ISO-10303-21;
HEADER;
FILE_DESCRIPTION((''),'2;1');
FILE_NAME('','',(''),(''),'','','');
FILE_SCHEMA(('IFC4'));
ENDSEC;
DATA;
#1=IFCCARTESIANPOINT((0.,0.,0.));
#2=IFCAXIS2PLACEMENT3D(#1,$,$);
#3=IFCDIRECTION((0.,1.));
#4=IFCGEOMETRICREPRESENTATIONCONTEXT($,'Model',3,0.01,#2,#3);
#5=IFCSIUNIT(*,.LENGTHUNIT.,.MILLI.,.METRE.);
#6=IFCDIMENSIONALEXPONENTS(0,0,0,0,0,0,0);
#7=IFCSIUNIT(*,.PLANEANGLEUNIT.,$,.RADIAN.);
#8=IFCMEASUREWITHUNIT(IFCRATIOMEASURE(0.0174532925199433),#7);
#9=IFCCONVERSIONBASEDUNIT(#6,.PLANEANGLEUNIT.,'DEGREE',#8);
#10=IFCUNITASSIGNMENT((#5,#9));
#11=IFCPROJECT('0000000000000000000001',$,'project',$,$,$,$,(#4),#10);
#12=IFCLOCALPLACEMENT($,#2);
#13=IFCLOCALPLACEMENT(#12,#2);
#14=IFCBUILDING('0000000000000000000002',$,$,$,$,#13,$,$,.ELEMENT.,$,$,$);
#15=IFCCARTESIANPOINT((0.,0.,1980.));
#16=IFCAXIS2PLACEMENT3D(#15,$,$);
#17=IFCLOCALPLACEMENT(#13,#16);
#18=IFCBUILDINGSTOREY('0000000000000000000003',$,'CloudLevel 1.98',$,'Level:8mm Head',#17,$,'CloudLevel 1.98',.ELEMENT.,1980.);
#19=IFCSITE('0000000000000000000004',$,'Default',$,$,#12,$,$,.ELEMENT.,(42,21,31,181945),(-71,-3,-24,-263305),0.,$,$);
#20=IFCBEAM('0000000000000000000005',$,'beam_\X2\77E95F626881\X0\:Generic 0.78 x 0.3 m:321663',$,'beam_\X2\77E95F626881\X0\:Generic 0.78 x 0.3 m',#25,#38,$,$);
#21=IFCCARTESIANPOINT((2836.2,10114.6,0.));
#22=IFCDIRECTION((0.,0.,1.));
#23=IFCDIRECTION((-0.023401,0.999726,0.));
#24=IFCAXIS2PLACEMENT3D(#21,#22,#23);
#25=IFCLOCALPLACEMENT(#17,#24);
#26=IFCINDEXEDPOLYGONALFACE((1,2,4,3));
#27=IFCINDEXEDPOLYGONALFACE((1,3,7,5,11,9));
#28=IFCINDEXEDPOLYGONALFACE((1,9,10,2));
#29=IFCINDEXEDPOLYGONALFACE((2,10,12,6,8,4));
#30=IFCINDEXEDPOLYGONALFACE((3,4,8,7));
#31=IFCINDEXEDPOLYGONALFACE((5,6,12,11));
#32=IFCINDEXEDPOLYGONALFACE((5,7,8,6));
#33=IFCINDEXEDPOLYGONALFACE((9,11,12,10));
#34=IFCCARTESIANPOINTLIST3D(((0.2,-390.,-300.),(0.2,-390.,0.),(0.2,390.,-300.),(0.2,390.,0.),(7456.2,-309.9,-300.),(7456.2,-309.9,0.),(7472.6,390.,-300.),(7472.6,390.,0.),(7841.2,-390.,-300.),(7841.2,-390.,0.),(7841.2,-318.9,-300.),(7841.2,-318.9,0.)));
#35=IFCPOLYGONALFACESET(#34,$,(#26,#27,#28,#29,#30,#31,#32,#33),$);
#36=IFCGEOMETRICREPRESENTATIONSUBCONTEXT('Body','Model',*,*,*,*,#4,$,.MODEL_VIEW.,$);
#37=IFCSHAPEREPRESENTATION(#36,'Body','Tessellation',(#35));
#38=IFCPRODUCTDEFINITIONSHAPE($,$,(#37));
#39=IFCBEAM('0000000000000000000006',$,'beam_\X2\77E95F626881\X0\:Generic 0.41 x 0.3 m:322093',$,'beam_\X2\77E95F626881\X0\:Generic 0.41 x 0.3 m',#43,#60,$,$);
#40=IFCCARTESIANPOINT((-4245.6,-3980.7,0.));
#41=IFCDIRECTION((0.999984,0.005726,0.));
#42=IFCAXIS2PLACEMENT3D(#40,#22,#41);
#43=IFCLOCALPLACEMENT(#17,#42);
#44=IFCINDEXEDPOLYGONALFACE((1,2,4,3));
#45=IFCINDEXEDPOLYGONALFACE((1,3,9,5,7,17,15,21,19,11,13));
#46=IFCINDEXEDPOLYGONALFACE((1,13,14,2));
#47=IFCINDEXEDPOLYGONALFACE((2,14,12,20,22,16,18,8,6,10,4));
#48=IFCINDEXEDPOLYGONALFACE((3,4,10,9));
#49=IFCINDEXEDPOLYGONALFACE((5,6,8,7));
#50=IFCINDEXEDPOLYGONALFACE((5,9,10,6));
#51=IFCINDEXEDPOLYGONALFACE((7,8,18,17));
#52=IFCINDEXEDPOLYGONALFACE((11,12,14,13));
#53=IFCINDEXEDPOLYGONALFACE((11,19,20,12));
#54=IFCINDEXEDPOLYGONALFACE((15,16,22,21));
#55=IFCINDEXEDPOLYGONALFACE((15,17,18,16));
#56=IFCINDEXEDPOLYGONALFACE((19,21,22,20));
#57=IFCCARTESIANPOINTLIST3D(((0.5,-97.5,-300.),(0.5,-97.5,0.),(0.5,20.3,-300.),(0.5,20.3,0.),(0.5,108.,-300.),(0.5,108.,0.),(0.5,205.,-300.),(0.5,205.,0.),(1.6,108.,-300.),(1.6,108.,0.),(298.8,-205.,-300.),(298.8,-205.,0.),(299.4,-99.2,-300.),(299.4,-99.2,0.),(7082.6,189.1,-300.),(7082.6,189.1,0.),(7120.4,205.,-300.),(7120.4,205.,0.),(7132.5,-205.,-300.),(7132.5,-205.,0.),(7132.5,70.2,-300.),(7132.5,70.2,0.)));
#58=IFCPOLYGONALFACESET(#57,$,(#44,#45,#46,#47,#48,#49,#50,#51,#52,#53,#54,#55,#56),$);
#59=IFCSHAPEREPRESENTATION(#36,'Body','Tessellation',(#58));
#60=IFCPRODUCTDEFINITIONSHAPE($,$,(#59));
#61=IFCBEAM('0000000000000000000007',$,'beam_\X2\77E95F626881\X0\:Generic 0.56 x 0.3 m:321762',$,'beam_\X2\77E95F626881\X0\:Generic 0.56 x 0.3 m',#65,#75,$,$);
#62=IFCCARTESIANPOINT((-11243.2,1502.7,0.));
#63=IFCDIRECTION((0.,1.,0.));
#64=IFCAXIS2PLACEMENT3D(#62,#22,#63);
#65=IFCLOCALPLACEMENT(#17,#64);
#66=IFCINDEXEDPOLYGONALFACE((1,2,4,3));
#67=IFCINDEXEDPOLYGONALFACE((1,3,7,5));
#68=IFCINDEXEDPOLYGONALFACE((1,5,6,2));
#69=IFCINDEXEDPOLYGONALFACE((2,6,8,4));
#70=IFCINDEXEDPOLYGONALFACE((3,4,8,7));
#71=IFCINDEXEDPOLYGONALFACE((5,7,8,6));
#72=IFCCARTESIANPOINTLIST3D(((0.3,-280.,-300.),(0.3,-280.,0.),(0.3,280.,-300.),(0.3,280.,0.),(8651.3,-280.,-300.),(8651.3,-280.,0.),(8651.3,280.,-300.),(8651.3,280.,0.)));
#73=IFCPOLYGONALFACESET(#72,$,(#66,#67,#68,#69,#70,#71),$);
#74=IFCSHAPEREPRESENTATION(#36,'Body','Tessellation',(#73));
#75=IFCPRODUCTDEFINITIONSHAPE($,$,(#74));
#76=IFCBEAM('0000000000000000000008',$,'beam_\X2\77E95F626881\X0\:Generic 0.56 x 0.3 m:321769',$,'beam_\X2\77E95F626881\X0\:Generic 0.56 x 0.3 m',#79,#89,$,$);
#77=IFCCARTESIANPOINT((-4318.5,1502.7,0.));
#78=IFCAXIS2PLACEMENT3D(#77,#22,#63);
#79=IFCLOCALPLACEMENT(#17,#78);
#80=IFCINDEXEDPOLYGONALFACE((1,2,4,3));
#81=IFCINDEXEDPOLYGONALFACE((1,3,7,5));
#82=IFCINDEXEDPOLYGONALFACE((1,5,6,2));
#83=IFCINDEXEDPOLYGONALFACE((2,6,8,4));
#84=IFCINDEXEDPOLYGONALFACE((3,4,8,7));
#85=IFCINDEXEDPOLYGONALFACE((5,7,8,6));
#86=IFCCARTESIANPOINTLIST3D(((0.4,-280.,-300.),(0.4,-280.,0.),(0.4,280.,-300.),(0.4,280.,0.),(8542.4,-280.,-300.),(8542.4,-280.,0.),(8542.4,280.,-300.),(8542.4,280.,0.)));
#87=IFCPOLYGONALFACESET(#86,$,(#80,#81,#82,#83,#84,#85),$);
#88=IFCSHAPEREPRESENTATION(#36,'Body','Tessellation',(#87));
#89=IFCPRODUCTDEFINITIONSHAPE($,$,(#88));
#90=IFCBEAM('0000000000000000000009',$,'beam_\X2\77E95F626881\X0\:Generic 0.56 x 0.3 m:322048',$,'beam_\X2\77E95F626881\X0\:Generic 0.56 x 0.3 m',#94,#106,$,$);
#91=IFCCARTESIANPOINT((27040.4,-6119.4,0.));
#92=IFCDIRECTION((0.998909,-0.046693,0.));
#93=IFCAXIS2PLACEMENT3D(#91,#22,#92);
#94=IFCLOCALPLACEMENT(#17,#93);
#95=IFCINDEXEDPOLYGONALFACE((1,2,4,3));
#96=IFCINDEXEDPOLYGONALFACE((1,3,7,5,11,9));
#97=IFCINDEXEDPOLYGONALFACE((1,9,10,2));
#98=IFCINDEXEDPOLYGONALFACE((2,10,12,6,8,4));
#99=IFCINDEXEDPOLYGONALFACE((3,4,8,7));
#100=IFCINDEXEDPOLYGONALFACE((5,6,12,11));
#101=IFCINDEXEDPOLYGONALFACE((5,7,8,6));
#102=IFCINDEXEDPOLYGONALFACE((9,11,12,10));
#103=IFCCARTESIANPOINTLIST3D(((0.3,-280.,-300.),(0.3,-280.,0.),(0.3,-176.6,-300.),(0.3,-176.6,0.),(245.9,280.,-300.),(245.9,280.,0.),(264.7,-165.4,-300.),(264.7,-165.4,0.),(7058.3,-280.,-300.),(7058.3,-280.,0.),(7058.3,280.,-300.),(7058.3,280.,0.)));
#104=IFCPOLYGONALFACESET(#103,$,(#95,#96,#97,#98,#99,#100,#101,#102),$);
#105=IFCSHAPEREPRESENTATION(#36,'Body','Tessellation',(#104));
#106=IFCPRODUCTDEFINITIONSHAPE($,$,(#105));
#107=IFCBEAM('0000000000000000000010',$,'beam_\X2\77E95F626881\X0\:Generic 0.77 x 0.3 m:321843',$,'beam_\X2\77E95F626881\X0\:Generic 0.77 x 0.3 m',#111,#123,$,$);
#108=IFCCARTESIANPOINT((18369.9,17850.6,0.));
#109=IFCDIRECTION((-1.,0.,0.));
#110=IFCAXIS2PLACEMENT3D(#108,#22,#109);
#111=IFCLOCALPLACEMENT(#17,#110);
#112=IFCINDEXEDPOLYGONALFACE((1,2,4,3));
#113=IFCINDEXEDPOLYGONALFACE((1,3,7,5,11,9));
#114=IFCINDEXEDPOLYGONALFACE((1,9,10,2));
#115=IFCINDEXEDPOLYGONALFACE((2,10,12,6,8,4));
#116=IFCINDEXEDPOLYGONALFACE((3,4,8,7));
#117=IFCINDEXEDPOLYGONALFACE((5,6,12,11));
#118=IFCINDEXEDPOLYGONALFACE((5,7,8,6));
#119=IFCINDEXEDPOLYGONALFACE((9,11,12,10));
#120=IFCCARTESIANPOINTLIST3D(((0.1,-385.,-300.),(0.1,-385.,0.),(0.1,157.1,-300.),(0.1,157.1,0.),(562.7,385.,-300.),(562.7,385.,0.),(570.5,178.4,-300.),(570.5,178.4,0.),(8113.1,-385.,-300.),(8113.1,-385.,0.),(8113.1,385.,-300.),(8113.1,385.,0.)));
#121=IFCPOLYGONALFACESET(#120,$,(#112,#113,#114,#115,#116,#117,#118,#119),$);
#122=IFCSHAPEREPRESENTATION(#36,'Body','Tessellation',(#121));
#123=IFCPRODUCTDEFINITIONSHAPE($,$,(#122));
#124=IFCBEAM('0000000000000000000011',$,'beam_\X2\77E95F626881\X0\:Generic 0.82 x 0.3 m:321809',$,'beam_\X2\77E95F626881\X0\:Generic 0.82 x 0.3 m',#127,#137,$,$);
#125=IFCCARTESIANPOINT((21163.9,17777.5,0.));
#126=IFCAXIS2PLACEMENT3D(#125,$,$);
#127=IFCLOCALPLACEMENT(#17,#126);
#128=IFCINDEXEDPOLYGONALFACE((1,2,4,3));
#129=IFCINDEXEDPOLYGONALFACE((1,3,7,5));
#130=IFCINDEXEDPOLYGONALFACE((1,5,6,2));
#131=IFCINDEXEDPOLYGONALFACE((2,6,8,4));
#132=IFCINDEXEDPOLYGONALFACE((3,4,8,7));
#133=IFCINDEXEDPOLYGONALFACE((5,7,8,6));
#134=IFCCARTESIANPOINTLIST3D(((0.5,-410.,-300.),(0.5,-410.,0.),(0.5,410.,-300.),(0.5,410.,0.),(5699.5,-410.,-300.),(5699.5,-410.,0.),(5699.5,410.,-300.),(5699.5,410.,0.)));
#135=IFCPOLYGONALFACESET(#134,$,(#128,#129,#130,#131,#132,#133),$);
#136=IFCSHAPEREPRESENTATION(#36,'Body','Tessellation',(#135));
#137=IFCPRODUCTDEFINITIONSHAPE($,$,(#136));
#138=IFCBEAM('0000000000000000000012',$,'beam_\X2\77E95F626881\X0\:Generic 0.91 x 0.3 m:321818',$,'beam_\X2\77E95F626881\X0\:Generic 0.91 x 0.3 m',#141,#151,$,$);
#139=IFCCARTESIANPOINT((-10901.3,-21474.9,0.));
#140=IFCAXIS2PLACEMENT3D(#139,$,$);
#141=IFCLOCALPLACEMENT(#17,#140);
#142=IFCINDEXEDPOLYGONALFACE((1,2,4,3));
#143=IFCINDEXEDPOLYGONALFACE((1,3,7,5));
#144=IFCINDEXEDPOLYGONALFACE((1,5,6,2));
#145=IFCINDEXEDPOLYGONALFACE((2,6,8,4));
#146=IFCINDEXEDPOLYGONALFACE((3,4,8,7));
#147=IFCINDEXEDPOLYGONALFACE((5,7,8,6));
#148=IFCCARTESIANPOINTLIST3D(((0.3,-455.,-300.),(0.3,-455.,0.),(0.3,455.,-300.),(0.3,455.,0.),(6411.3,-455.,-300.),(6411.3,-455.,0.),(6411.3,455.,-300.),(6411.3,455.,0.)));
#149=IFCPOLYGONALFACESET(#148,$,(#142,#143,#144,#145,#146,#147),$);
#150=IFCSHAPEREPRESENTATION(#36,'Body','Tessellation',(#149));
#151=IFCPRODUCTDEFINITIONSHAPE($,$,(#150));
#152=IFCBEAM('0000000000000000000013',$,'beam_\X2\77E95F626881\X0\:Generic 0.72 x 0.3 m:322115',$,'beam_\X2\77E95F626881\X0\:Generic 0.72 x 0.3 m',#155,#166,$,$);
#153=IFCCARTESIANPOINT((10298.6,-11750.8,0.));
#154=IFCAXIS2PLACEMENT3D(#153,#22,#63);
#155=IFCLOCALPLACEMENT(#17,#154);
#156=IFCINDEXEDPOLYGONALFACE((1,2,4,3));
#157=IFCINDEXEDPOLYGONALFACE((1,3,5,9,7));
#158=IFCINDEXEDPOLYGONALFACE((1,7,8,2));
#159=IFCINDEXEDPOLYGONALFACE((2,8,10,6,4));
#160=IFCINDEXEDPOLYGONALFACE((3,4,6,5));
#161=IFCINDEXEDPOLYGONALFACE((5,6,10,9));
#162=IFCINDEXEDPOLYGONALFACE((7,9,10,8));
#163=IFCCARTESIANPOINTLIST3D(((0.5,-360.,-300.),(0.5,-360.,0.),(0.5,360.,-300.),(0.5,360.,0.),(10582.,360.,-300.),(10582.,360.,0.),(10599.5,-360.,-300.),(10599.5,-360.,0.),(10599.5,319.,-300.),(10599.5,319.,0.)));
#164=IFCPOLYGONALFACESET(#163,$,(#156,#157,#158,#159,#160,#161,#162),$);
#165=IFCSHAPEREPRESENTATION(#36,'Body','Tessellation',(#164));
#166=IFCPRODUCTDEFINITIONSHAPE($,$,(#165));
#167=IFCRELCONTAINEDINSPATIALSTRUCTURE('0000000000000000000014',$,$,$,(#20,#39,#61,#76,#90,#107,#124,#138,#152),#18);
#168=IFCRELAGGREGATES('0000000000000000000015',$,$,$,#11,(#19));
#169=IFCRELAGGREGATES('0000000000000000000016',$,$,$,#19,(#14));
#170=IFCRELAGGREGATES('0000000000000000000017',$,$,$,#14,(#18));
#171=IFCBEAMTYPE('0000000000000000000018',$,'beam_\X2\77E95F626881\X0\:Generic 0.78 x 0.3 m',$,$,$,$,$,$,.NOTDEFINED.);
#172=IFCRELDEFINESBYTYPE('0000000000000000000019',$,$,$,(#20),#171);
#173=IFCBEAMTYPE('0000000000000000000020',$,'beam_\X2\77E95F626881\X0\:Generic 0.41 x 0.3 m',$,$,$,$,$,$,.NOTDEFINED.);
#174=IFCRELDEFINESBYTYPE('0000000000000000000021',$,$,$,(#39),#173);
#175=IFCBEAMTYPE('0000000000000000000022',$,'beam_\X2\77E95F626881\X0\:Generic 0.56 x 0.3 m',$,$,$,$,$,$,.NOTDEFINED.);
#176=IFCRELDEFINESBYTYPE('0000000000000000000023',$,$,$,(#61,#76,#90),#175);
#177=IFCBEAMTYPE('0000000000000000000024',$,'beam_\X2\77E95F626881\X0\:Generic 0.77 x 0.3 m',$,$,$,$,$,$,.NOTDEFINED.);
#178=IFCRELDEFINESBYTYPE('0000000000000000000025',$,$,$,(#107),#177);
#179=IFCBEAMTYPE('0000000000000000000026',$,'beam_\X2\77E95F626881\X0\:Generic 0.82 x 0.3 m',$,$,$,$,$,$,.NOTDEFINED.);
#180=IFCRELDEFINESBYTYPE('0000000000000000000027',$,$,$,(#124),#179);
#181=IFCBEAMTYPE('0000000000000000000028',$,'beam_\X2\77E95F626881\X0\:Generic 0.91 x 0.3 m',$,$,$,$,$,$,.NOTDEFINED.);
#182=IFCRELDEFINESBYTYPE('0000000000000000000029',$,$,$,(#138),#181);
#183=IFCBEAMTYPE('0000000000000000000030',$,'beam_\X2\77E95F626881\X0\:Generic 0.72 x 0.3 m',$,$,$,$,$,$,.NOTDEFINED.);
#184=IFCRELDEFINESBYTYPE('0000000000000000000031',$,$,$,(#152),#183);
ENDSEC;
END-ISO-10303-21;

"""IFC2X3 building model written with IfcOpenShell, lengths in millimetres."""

from ifc_helpers import new_model, entity, si_unit, converted_unit, direction, frame, frame_2d, origin, place, context, subcontext, project, spatial, polyline, rectangle, extrude, clip, halfspace, bounded_halfspace, type_object, element, save


model = new_model("IFC2X3")

# Units and contexts
model_context = context("Model", 3, precision=0.01, world=origin(), true_north=direction((0.0, 1.0)))
body_context = subcontext(model_context, "Body", "Model", "MODEL_VIEW")
ifc_project = project(units=[si_unit("LENGTHUNIT", "METRE", prefix="MILLI"), converted_unit("PLANEANGLEUNIT", "DEGREE", entity("IfcRatioMeasure", 0.0174532925199433), si_unit("PLANEANGLEUNIT", "RADIAN"), dimensions=[0, 0, 0, 0, 0, 0, 0])], contexts=[model_context])

# Site, building, storey
site_placement = place(None, origin())
site = spatial("IfcSite", under=ifc_project, at=site_placement, Name="Default", CompositionType="ELEMENT", RefLatitude=(42, 21, 31, 181945), RefLongitude=(-71, -3, -24, -263305), RefElevation=0.0)
building_placement = place(site_placement, origin())
building = spatial("IfcBuilding", under=site, at=building_placement, CompositionType="ELEMENT")
storey_placement = place(building_placement, frame((0.0, 0.0, 1980.0)))
storey = spatial("IfcBuildingStorey", under=building, at=storey_placement, Name="CloudLevel 1.98", ObjectType="Level:8mm Head", LongName="CloudLevel 1.98", CompositionType="ELEMENT", Elevation=1980.0)

# Beams
beam_type_1 = type_object("IfcBeamType", Name="beam_矩形梁:Generic 0.78 x 0.3 m", PredefinedType="NOTDEFINED")
beam_1_placement = place(storey_placement, frame((2836.2, 10114.6, 0.0), z_axis=(0.0, 0.0, 1.0), x_axis=(-0.023401, 0.999726, 0.0)))
element("IfcBeam", 1, at=beam_1_placement, inside=storey, type_object=beam_type_1, Name="beam_矩形梁:Generic 0.78 x 0.3 m:321663", ObjectType="beam_矩形梁:Generic 0.78 x 0.3 m", context=body_context, shape_type="SweptSolid", body=[
    clip(clip(extrude(rectangle(XDim=300.0, YDim=780.0, at=frame_2d((0.0, 0.0), x_axis=(1.0, 0.0))), frame((0.2, 0.0, -150.0), z_axis=(1.0, 0.0, 0.0), x_axis=(0.0, 0.0, -1.0)), (0.0, 0.0, 1.0), 7841.0), bounded_halfspace(frame((7676.1, -315.1, -150.0), z_axis=(0.023401, 0.999726, 0.0), x_axis=(0.0, 0.0, 1.0)), False, frame((0.2, 0.0, -150.0), z_axis=(1.0, 0.0, 0.0), x_axis=(0.0, 0.0, -1.0)), polyline([(150.0, -309.9), (-150.0, -309.9), (-150.0, -318.9), (150.0, -318.9), (150.0, -309.9)]))), bounded_halfspace(frame((7627.0, 6987.1, -300.0), z_axis=(0.999726, -0.023401, 0.0), x_axis=(-0.023401, -0.999726, 0.0)), False, frame((0.2, 0.0, -150.0), z_axis=(1.0, 0.0, 0.0), x_axis=(0.0, 0.0, -1.0)), polyline([(-150.0, -309.9), (150.0, -309.9), (150.0, 390.0), (-150.0, 390.0), (-150.0, -309.9)]))),
])
beam_type_2 = type_object("IfcBeamType", Name="beam_矩形梁:Generic 0.41 x 0.3 m", PredefinedType="NOTDEFINED")
beam_2_placement = place(storey_placement, frame((-4245.6, -3980.7, 0.0), z_axis=(0.0, 0.0, 1.0), x_axis=(0.999984, 0.005726, 0.0)))
element("IfcBeam", 2, at=beam_2_placement, inside=storey, type_object=beam_type_2, Name="beam_矩形梁:Generic 0.41 x 0.3 m:322093", ObjectType="beam_矩形梁:Generic 0.41 x 0.3 m", context=body_context, shape_type="SweptSolid", body=[
    clip(clip(clip(clip(clip(clip(extrude(rectangle(XDim=300.0, YDim=410.0, at=frame_2d((0.0, 0.0), x_axis=(1.0, 0.0))), frame((0.5, 0.0, -150.0), z_axis=(1.0, 0.0, 0.0), x_axis=(0.0, 0.0, -1.0)), (0.0, 0.0, 1.0), 7132.0), bounded_halfspace(frame((253.0, -8215.1, -300.0), z_axis=(-0.999984, 0.005726, 0.0), x_axis=(0.005726, 0.999984, 0.0)), False, frame((0.5, 0.0, -150.0), z_axis=(1.0, 0.0, 0.0), x_axis=(0.0, 0.0, -1.0)), polyline([(-150.0, -99.2), (150.0, -99.2), (150.0, -205.0), (-150.0, -205.0), (-150.0, -99.2)]))), bounded_halfspace(frame((-0.6, -97.5, -150.0), z_axis=(-0.005726, -0.999984, 0.0), x_axis=(0.0, 0.0, 1.0)), False, frame((0.5, 0.0, -150.0), z_axis=(1.0, 0.0, 0.0), x_axis=(0.0, 0.0, -1.0)), polyline([(150.0, -99.2), (-150.0, -99.2), (-150.0, -97.5), (150.0, -97.5), (150.0, -99.2)]))), bounded_halfspace(frame((-1.0, -97.0, -150.0), z_axis=(-0.999918, 0.012795, 0.0), x_axis=(0.0, 0.0, 1.0)), False, frame((0.5, 0.0, -150.0), z_axis=(1.0, 0.0, 0.0), x_axis=(0.0, 0.0, -1.0)), polyline([(-150.0, 108.0), (150.0, 108.0), (150.0, 20.3), (-150.0, 20.3), (-150.0, 108.0)]))), bounded_halfspace(frame((1.6, 108.0, -300.0), z_axis=(-0.012795, -0.999918, 0.0), x_axis=(-0.999918, 0.012795, 0.0)), False, frame((0.5, 0.0, -150.0), z_axis=(1.0, 0.0, 0.0), x_axis=(0.0, 0.0, -1.0)), polyline([(150.0, 108.0), (-150.0, 108.0), (-150.0, 108.0), (150.0, 108.0), (150.0, 108.0)]))), bounded_halfspace(frame((14379.4, 3250.4, -300.0), z_axis=(0.386871, -0.922134, 0.0), x_axis=(-0.922134, -0.386871, 0.0)), False, frame((0.5, 0.0, -150.0), z_axis=(1.0, 0.0, 0.0), x_axis=(0.0, 0.0, -1.0)), polyline([(-150.0, 189.1), (150.0, 189.1), (150.0, 205.0), (-150.0, 205.0), (-150.0, 189.1)]))), bounded_halfspace(frame((7161.9, 0.1, -150.0), z_axis=(0.922134, 0.386871, 0.0), x_axis=(0.0, 0.0, 1.0)), False, frame((0.5, 0.0, -150.0), z_axis=(1.0, 0.0, 0.0), x_axis=(0.0, 0.0, -1.0)), polyline([(150.0, 189.1), (-150.0, 189.1), (-150.0, 70.2), (150.0, 70.2), (150.0, 189.1)]))),
])
beam_type_3 = type_object("IfcBeamType", Name="beam_矩形梁:Generic 0.56 x 0.3 m", PredefinedType="NOTDEFINED")
beam_3_placement = place(storey_placement, frame((-11243.2, 1502.7, 0.0), z_axis=(0.0, 0.0, 1.0), x_axis=(0.0, 1.0, 0.0)))
element("IfcBeam", 3, at=beam_3_placement, inside=storey, type_object=beam_type_3, Name="beam_矩形梁:Generic 0.56 x 0.3 m:321762", ObjectType="beam_矩形梁:Generic 0.56 x 0.3 m", context=body_context, shape_type="SweptSolid", body=[
    extrude(rectangle(XDim=300.0, YDim=560.0, at=frame_2d((0.0, 0.0), x_axis=(1.0, 0.0))), frame((0.3, 0.0, -150.0), z_axis=(1.0, 0.0, 0.0), x_axis=(0.0, 0.0, -1.0)), (0.0, 0.0, 1.0), 8651.0),
])
beam_4_placement = place(storey_placement, frame((-4318.5, 1502.7, 0.0), z_axis=(0.0, 0.0, 1.0), x_axis=(0.0, 1.0, 0.0)))
element("IfcBeam", 4, at=beam_4_placement, inside=storey, type_object=beam_type_3, Name="beam_矩形梁:Generic 0.56 x 0.3 m:321769", ObjectType="beam_矩形梁:Generic 0.56 x 0.3 m", context=body_context, shape_type="SweptSolid", body=[
    extrude(rectangle(XDim=300.0, YDim=560.0, at=frame_2d((0.0, 0.0), x_axis=(1.0, 0.0))), frame((0.4, 0.0, -150.0), z_axis=(1.0, 0.0, 0.0), x_axis=(0.0, 0.0, -1.0)), (0.0, 0.0, 1.0), 8542.0),
])
beam_5_placement = place(storey_placement, frame((27040.4, -6119.4, 0.0), z_axis=(0.0, 0.0, 1.0), x_axis=(0.998909, -0.046693, 0.0)))
element("IfcBeam", 5, at=beam_5_placement, inside=storey, type_object=beam_type_3, Name="beam_矩形梁:Generic 0.56 x 0.3 m:322048", ObjectType="beam_矩形梁:Generic 0.56 x 0.3 m", context=body_context, shape_type="SweptSolid", body=[
    clip(clip(extrude(rectangle(XDim=300.0, YDim=560.0, at=frame_2d((0.0, 0.0), x_axis=(1.0, 0.0))), frame((0.3, 0.0, -150.0), z_axis=(1.0, 0.0, 0.0), x_axis=(0.0, 0.0, -1.0)), (0.0, 0.0, 1.0), 7058.0), bounded_halfspace(frame((37.5, 5201.8, 0.0), z_axis=(-0.999105, -0.042298, 0.0), x_axis=(0.042298, -0.999105, 0.0)), False, frame((0.3, 0.0, -150.0), z_axis=(1.0, 0.0, 0.0), x_axis=(0.0, 0.0, -1.0)), polyline([(150.0, -165.4), (-150.0, -165.4), (-150.0, 280.0), (150.0, 280.0), (150.0, -165.4)]))), bounded_halfspace(frame((0.0, -176.6, -150.0), z_axis=(-0.042298, 0.999105, 0.0), x_axis=(0.0, 0.0, 1.0)), False, frame((0.3, 0.0, -150.0), z_axis=(1.0, 0.0, 0.0), x_axis=(0.0, 0.0, -1.0)), polyline([(-150.0, -165.4), (150.0, -165.4), (150.0, -176.6), (-150.0, -176.6), (-150.0, -165.4)]))),
])
beam_type_4 = type_object("IfcBeamType", Name="beam_矩形梁:Generic 0.77 x 0.3 m", PredefinedType="NOTDEFINED")
beam_6_placement = place(storey_placement, frame((18369.9, 17850.6, 0.0), z_axis=(0.0, 0.0, 1.0), x_axis=(-1.0, 0.0, 0.0)))
element("IfcBeam", 6, at=beam_6_placement, inside=storey, type_object=beam_type_4, Name="beam_矩形梁:Generic 0.77 x 0.3 m:321843", ObjectType="beam_矩形梁:Generic 0.77 x 0.3 m", context=body_context, shape_type="SweptSolid", body=[
    clip(clip(extrude(rectangle(XDim=300.0, YDim=770.0, at=frame_2d((0.0, 0.0), x_axis=(1.0, 0.0))), frame((0.1, 0.0, -150.0), z_axis=(1.0, 0.0, 0.0), x_axis=(0.0, 0.0, -1.0)), (0.0, 0.0, 1.0), 8113.0), bounded_halfspace(frame((220.7, 165.3, -150.0), z_axis=(-0.037424, 0.999299, 0.0), x_axis=(0.0, 0.0, 1.0)), False, frame((0.1, 0.0, -150.0), z_axis=(1.0, 0.0, 0.0), x_axis=(0.0, 0.0, -1.0)), polyline([(-150.0, 178.4), (150.0, 178.4), (150.0, 157.1), (-150.0, 157.1), (-150.0, 178.4)]))), bounded_halfspace(frame((280.4, 7925.0, 0.0), z_axis=(-0.999299, -0.037424, 0.0), x_axis=(0.037424, -0.999299, 0.0)), False, frame((0.1, 0.0, -150.0), z_axis=(1.0, 0.0, 0.0), x_axis=(0.0, 0.0, -1.0)), polyline([(150.0, 178.4), (-150.0, 178.4), (-150.0, 385.0), (150.0, 385.0), (150.0, 178.4)]))),
])
beam_type_5 = type_object("IfcBeamType", Name="beam_矩形梁:Generic 0.82 x 0.3 m", PredefinedType="NOTDEFINED")
beam_7_placement = place(storey_placement, frame((21163.9, 17777.5, 0.0)))
element("IfcBeam", 7, at=beam_7_placement, inside=storey, type_object=beam_type_5, Name="beam_矩形梁:Generic 0.82 x 0.3 m:321809", ObjectType="beam_矩形梁:Generic 0.82 x 0.3 m", context=body_context, shape_type="SweptSolid", body=[
    extrude(rectangle(XDim=300.0, YDim=820.0, at=frame_2d((0.0, 0.0), x_axis=(1.0, 0.0))), frame((0.5, 0.0, -150.0), z_axis=(1.0, 0.0, 0.0), x_axis=(0.0, 0.0, -1.0)), (0.0, 0.0, 1.0), 5699.0),
])
beam_type_6 = type_object("IfcBeamType", Name="beam_矩形梁:Generic 0.91 x 0.3 m", PredefinedType="NOTDEFINED")
beam_8_placement = place(storey_placement, frame((-10901.3, -21474.9, 0.0)))
element("IfcBeam", 8, at=beam_8_placement, inside=storey, type_object=beam_type_6, Name="beam_矩形梁:Generic 0.91 x 0.3 m:321818", ObjectType="beam_矩形梁:Generic 0.91 x 0.3 m", context=body_context, shape_type="SweptSolid", body=[
    extrude(rectangle(XDim=300.0, YDim=910.0, at=frame_2d((0.0, 0.0), x_axis=(1.0, 0.0))), frame((0.3, 0.0, -150.0), z_axis=(1.0, 0.0, 0.0), x_axis=(0.0, 0.0, -1.0)), (0.0, 0.0, 1.0), 6411.0),
])
beam_type_7 = type_object("IfcBeamType", Name="beam_矩形梁:Generic 0.72 x 0.3 m", PredefinedType="NOTDEFINED")
beam_9_placement = place(storey_placement, frame((10298.6, -11750.8, 0.0), z_axis=(0.0, 0.0, 1.0), x_axis=(0.0, 1.0, 0.0)))
element("IfcBeam", 9, at=beam_9_placement, inside=storey, type_object=beam_type_7, Name="beam_矩形梁:Generic 0.72 x 0.3 m:322115", ObjectType="beam_矩形梁:Generic 0.72 x 0.3 m", context=body_context, shape_type="SweptSolid", body=[
    clip(extrude(rectangle(XDim=300.0, YDim=720.0, at=frame_2d((0.0, 0.0), x_axis=(1.0, 0.0))), frame((0.5, 0.0, -150.0), z_axis=(1.0, 0.0, 0.0), x_axis=(0.0, 0.0, -1.0)), (0.0, 0.0, 1.0), 10599.0), halfspace(frame((10725.7, 22.9, 0.0), z_axis=(0.919903, 0.392145, 0.0), x_axis=(-0.392145, 0.919903, 0.0)), False)),
])

save(model, "model.ifc")
